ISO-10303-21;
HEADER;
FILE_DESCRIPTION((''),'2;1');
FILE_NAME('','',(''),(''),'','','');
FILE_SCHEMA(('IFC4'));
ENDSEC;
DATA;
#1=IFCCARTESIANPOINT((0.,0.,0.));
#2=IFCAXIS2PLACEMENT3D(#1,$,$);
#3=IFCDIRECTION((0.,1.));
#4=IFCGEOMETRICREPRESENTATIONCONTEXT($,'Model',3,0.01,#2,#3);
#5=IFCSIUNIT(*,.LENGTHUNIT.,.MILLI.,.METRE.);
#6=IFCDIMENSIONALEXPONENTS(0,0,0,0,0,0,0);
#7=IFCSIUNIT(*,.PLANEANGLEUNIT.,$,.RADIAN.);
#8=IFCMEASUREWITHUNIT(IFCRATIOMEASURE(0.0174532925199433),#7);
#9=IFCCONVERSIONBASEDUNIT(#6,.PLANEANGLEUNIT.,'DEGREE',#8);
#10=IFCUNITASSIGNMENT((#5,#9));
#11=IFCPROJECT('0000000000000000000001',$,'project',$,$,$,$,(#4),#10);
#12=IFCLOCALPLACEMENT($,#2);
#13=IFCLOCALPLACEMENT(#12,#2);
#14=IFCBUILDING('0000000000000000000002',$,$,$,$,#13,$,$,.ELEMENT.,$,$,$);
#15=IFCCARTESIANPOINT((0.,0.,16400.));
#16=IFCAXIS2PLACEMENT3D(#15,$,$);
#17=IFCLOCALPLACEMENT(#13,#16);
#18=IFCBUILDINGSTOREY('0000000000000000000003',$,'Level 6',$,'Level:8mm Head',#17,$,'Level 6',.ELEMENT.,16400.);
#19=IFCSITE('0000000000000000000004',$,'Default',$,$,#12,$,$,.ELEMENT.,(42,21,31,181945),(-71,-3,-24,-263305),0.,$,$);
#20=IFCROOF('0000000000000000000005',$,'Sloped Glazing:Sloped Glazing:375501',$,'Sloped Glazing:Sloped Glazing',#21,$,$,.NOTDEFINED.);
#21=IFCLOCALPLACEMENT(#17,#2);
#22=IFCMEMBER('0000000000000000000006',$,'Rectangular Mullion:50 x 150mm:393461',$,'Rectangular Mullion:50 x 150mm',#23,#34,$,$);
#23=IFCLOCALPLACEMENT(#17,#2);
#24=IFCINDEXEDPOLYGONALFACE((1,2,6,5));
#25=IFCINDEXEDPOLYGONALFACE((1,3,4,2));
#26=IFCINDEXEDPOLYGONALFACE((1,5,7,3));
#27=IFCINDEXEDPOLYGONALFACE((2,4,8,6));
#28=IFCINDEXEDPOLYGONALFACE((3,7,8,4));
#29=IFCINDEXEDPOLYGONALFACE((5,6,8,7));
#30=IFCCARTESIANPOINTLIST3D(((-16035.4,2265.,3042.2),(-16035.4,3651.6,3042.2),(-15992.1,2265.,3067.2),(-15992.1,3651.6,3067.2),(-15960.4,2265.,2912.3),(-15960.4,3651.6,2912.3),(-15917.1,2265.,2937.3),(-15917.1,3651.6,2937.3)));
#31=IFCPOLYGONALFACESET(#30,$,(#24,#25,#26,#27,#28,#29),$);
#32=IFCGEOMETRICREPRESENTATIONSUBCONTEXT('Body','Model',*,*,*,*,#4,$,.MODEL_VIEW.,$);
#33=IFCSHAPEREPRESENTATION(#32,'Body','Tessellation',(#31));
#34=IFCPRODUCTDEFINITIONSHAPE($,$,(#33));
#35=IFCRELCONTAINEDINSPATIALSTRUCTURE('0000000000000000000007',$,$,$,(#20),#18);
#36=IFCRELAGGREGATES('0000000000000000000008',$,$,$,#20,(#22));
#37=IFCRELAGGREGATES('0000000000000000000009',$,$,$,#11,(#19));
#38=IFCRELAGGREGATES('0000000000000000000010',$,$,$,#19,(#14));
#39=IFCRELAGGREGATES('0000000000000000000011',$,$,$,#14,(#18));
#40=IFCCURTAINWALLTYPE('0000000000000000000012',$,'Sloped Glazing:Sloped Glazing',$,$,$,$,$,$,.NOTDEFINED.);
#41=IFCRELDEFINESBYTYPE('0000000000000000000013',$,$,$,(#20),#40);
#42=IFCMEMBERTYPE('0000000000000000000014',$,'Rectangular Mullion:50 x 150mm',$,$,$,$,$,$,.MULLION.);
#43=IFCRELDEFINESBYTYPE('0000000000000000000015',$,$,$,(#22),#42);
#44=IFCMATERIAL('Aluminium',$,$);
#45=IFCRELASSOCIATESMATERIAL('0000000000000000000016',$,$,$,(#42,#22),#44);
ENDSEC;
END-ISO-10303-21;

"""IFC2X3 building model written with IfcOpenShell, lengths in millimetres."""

from ifc_helpers import new_model, entity, si_unit, converted_unit, direction, frame, origin, origin_2d_with_axis, place, context, subcontext, project, spatial, rectangle, extrude, source, transform, mapped, material, type_object, type_shapes, element, aggregate, save


model = new_model("IFC2X3")

# Units and contexts
model_context = context("Model", 3, precision=0.01, world=origin(), true_north=direction((0.0, 1.0)))
body_context = subcontext(model_context, "Body", "Model", "MODEL_VIEW")
ifc_project = project(units=[si_unit("LENGTHUNIT", "METRE", prefix="MILLI"), converted_unit("PLANEANGLEUNIT", "DEGREE", entity("IfcRatioMeasure", 0.0174532925199433), si_unit("PLANEANGLEUNIT", "RADIAN"), dimensions=[0, 0, 0, 0, 0, 0, 0])], contexts=[model_context])

# Site, building, storey
site_placement = place(None, frame((0.0, 0.0, 0.0)))
site = spatial("IfcSite", under=ifc_project, at=site_placement, Name="Default", CompositionType="ELEMENT", RefLatitude=(42, 21, 31, 181945), RefLongitude=(-71, -3, -24, -263305), RefElevation=0.0)
building_placement = place(site_placement, origin())
building = spatial("IfcBuilding", under=site, at=building_placement, CompositionType="ELEMENT")
storey_placement = place(building_placement, frame((0.0, 0.0, 16400.0)))
storey = spatial("IfcBuildingStorey", under=building, at=storey_placement, Name="Level 6", ObjectType="Level:8mm Head", LongName="Level 6", CompositionType="ELEMENT", Elevation=16400.0)

# Roof, member
curtain_wall_type = type_object("IfcCurtainWallType", Name="Sloped Glazing:Sloped Glazing", PredefinedType="NOTDEFINED")
roof_placement = place(storey_placement, frame((0.0, 0.0, -16400.0)))
roof = element("IfcRoof", 1, at=roof_placement, inside=storey, type_object=curtain_wall_type, Name="Sloped Glazing:Sloped Glazing:375501", ObjectType="Sloped Glazing:Sloped Glazing", ShapeType="NOTDEFINED")
ifc_material_1 = material(Name="Aluminium")
member_type_1 = type_object("IfcMemberType", Name="Rectangular Mullion:50 x 150mm", PredefinedType="MULLION", material=ifc_material_1)
shared_shape_1 = source(origin(), body_context, "Body", "SweptSolid", [
    extrude(rectangle(XDim=150.0, YDim=50.0, at=origin_2d_with_axis()), frame((-25.0, 0.0, -1386.6), z_axis=(0.0, 0.0, 1.0), x_axis=(0.0, -1.0, 0.0)), (0.0, 0.0, 1.0), 1386.6),
])
type_shapes(member_type_1, [shared_shape_1])
member_1_placement = place(storey_placement, frame((-15954.6, 3651.6, 3002.2), z_axis=(0.0, 1.0, 0.0), x_axis=(0.866025, 0.0, 0.5)))
member_1 = element("IfcMember", 2, at=member_1_placement, type_object=member_type_1, material=ifc_material_1, Name="Rectangular Mullion:50 x 150mm:393461", ObjectType="Rectangular Mullion:50 x 150mm", context=body_context, shape_type="MappedRepresentation", body=[
    mapped(shared_shape_1, transform((0.0, 0.0, 0.0), scale=1.0)),
])
aggregate(roof, [member_1])

save(model, "model.ifc")
